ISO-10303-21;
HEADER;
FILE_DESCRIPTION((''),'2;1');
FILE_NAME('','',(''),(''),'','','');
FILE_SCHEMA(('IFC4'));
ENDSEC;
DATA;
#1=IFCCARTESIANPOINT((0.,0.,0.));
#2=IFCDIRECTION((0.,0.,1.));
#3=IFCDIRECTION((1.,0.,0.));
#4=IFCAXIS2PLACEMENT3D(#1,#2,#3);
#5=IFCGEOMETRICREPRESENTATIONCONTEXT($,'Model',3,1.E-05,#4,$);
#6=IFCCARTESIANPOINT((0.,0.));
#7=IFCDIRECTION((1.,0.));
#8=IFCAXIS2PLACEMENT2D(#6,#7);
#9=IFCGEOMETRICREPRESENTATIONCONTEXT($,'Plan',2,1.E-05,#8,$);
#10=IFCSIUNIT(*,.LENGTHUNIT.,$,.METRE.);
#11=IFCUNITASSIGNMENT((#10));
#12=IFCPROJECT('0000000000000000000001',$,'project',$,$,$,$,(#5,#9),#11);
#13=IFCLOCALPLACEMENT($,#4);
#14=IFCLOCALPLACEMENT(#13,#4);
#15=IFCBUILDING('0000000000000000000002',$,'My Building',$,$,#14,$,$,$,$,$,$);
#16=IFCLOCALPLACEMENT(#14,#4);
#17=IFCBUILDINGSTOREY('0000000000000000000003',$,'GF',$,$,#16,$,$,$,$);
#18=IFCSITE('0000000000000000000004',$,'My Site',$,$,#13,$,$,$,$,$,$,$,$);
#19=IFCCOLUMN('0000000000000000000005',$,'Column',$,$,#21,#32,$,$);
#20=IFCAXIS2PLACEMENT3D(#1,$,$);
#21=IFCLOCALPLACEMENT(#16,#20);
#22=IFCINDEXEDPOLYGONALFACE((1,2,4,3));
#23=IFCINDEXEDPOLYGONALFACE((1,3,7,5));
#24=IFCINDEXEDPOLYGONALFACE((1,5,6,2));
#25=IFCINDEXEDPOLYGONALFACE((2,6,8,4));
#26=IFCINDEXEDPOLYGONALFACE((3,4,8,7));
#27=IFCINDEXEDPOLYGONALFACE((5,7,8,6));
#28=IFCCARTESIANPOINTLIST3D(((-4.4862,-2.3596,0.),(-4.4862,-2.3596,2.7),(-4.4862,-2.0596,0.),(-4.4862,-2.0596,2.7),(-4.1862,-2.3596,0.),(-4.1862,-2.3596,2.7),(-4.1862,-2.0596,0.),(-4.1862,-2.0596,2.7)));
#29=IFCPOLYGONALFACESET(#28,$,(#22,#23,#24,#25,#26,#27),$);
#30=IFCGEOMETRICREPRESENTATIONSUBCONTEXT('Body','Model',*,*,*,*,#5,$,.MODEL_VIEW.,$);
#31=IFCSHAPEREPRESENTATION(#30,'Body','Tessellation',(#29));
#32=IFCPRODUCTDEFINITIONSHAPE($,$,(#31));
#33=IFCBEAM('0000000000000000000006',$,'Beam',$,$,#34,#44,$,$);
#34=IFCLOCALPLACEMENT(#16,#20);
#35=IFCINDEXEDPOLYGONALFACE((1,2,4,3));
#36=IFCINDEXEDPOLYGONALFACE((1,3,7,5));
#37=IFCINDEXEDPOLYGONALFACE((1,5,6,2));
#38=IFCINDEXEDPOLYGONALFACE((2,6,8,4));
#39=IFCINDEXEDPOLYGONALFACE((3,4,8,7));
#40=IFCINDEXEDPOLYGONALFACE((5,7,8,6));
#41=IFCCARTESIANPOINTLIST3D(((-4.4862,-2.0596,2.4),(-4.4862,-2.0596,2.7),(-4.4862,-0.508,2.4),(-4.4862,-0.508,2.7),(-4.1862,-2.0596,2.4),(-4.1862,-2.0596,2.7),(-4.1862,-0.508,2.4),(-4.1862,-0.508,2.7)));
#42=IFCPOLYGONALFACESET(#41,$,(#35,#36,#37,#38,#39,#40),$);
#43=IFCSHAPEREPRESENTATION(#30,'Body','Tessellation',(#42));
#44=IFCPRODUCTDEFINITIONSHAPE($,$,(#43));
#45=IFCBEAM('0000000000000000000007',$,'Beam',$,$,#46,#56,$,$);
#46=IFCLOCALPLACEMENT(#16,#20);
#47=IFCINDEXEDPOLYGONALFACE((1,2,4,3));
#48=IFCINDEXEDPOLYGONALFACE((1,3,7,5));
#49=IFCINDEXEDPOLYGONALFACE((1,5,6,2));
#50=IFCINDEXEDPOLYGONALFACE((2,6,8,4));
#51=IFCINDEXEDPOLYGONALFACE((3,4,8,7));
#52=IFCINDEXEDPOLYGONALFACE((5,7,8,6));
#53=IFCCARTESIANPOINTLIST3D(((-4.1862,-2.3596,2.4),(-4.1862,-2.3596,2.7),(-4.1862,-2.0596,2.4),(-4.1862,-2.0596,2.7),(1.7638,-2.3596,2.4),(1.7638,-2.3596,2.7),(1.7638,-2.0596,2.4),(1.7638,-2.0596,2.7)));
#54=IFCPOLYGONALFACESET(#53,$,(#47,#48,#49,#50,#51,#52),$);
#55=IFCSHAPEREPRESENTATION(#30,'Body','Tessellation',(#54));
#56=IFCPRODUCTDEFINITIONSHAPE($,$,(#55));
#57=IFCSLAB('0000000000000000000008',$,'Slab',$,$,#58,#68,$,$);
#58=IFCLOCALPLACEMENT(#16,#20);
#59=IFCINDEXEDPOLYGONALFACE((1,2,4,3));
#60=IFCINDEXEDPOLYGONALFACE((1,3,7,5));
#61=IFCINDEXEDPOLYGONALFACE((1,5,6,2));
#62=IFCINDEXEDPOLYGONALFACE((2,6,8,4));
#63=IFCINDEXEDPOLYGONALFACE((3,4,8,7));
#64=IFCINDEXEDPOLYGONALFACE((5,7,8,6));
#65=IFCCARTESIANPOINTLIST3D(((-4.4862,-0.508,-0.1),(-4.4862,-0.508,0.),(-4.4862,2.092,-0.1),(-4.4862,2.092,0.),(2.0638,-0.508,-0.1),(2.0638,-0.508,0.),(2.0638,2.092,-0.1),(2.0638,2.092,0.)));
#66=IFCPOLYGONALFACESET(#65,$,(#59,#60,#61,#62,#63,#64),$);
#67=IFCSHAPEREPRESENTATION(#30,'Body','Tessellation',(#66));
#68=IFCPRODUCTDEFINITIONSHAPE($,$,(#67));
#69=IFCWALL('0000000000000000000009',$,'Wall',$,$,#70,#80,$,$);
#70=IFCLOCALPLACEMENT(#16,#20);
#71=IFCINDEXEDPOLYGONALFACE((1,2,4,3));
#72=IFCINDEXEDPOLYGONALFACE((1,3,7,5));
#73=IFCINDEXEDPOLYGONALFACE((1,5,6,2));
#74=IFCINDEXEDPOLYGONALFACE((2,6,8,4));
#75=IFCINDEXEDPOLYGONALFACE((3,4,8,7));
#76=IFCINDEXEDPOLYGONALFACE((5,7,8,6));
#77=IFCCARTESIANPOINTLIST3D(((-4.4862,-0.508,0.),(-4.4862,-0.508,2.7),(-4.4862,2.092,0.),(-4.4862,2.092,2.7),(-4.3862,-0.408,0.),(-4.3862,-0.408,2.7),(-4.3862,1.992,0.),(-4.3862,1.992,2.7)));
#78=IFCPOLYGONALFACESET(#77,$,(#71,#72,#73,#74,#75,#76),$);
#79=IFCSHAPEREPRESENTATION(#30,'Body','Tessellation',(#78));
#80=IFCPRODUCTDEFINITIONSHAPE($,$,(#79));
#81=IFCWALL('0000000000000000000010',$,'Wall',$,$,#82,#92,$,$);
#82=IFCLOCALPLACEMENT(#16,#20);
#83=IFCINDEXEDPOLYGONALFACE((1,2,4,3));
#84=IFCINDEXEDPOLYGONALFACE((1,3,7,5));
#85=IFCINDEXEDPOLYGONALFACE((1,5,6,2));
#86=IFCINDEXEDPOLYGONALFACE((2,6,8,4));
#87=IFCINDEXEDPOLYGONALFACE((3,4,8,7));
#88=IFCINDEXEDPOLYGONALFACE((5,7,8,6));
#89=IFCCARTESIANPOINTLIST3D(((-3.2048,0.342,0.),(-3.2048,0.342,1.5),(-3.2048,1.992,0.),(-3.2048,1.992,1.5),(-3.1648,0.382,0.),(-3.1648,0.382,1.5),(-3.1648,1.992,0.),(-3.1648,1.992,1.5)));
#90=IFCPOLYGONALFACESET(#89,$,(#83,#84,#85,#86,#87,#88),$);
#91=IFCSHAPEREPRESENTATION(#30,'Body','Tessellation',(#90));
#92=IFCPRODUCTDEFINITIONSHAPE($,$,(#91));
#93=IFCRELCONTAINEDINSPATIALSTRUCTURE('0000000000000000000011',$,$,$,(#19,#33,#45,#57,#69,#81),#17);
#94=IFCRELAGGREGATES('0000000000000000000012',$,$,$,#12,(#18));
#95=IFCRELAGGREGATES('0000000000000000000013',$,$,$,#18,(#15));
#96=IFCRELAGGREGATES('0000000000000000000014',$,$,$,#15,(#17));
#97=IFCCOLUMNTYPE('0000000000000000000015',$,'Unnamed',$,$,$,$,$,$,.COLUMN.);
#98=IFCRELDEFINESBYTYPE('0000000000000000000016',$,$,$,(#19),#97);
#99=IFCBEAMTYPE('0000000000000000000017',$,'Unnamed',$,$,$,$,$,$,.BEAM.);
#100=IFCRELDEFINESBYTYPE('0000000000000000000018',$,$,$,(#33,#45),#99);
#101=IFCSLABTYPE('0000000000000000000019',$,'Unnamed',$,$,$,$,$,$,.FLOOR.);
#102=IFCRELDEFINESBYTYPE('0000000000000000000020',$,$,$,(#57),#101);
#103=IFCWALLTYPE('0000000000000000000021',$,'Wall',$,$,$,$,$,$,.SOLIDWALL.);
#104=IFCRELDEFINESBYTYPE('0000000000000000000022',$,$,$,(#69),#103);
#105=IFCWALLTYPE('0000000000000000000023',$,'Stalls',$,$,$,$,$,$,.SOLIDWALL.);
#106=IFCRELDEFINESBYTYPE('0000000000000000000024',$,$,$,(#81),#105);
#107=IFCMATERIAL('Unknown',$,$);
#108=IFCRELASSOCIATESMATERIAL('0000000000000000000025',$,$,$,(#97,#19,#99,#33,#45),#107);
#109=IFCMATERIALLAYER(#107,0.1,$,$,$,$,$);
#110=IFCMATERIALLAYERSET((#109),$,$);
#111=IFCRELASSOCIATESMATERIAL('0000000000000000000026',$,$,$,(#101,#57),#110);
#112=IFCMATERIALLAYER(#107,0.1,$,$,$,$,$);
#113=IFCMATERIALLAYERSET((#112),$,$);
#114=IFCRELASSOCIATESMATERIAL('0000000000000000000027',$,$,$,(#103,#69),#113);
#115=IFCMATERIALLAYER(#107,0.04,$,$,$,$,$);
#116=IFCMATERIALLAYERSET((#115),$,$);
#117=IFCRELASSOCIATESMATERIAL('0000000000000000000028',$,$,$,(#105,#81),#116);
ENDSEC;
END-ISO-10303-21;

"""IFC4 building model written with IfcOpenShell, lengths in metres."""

from ifc_helpers import new_model, si_unit, frame, origin_with_axes, origin_2d_with_axis, place, context, subcontext, project, spatial, line, indexed_curve, rectangle, outline, extrude, material, layer, layer_set, layer_usage, material_profile, profile_set, profile_usage, type_object, element, save


model = new_model("IFC4")

# Units and contexts
model_context = context("Model", 3, precision=1e-05, world=origin_with_axes())
plan_context = context("Plan", 2, precision=1e-05, world=origin_2d_with_axis())
body_context_1 = subcontext(model_context, "Body", "Model", "MODEL_VIEW")
ifc_project = project(units=[si_unit("LENGTHUNIT", "METRE")], contexts=[model_context, plan_context])

# Site, building, storey
site_placement = place(None, origin_with_axes())
site = spatial("IfcSite", under=ifc_project, at=site_placement, Name="My Site")
building_placement = place(site_placement, origin_with_axes())
building = spatial("IfcBuilding", under=site, at=building_placement, Name="My Building")
storey_placement = place(building_placement, origin_with_axes())
storey = spatial("IfcBuildingStorey", under=building, at=storey_placement, Name="GF")

# Column
ifc_material = material(Name="Unknown")
ifc_material_profile_1 = material_profile(ifc_material, rectangle(XDim=0.3, YDim=0.3))
ifc_profile_set_1 = profile_set([ifc_material_profile_1])
ifc_profile_usage_1 = profile_usage(ifc_profile_set_1, cardinal=6)
column_type = type_object("IfcColumnType", Name="Unnamed", PredefinedType="COLUMN", material=ifc_profile_set_1)
column_placement = place(storey_placement, frame((-4.4862, -2.2096, 0.0), z_axis=(0.0, 0.0, 1.0), x_axis=(1.0, 0.0, 0.0)))
element("IfcColumn", 1, at=column_placement, inside=storey, type_object=column_type, material=ifc_profile_usage_1, Name="Column", context=body_context_1, shape_type="SweptSolid", body=[
    extrude(rectangle(XDim=0.3, YDim=0.3), frame((0.15, 0.0, 0.0), z_axis=(0.0, 0.0, 1.0), x_axis=(1.0, 0.0, 0.0)), (0.0, 0.0, 1.0), 2.7),
])

# Beams
ifc_material_profile_2 = material_profile(ifc_material, rectangle(XDim=0.3, YDim=0.3))
ifc_profile_set_2 = profile_set([ifc_material_profile_2])
ifc_profile_usage_2 = profile_usage(ifc_profile_set_2, cardinal=9)
beam_type = type_object("IfcBeamType", Name="Unnamed", PredefinedType="BEAM", material=ifc_profile_set_2)
beam_1_placement = place(storey_placement, frame((-4.4862, -0.508, 2.7), z_axis=(0.0, -1.0, 0.0), x_axis=(1.0, 0.0, 0.0)))
element("IfcBeam", 2, at=beam_1_placement, inside=storey, type_object=beam_type, material=ifc_profile_usage_2, Name="Beam", context=body_context_1, shape_type="SweptSolid", body=[
    extrude(rectangle(XDim=0.3, YDim=0.3), frame((0.15, -0.15, 0.0), z_axis=(0.0, 0.0, 1.0), x_axis=(1.0, 0.0, 0.0)), (0.0, 0.0, 1.0), 1.5515),
])
ifc_profile_usage_3 = profile_usage(ifc_profile_set_2, cardinal=7)
beam_2_placement = place(storey_placement, frame((-4.1862, -2.0596, 2.7), z_axis=(1.0, 0.0, 0.0), x_axis=(0.0, 1.0, 0.0)))
element("IfcBeam", 3, at=beam_2_placement, inside=storey, type_object=beam_type, material=ifc_profile_usage_3, Name="Beam", context=body_context_1, shape_type="SweptSolid", body=[
    extrude(rectangle(XDim=0.3, YDim=0.3), frame((-0.15, -0.15, 0.0), z_axis=(0.0, 0.0, 1.0), x_axis=(1.0, 0.0, 0.0)), (0.0, 0.0, 1.0), 5.95),
])

# Slab
ifc_layer_1 = layer(ifc_material, 0.1)
ifc_layer_set_1 = layer_set([ifc_layer_1])
ifc_layer_usage_1 = layer_usage(ifc_layer_set_1, "AXIS3", "POSITIVE", -0.1)
slab_type = type_object("IfcSlabType", Name="Unnamed", PredefinedType="FLOOR", material=ifc_layer_set_1)
slab_placement = place(storey_placement, frame((-4.4862, 2.092, 0.0), z_axis=(0.0, 0.0, 1.0), x_axis=(1.0, 0.0, 0.0)))
element("IfcSlab", 4, at=slab_placement, inside=storey, type_object=slab_type, material=ifc_layer_usage_1, Name="Slab", context=body_context_1, shape_type="SweptSolid", body=[
    extrude(outline(indexed_curve([(0.0, 0.0), (0.0, -2.6), (6.55, -2.6), (6.55, 0.0), (0.0, 0.0)])), frame((0.0, 0.0, -0.1), z_axis=(0.0, 0.0, 1.0), x_axis=(1.0, 0.0, 0.0)), (0.0, 0.0, 1.0), 0.1),
])

# Wall
ifc_layer_2 = layer(ifc_material, 0.1)
ifc_layer_set_2 = layer_set([ifc_layer_2])
ifc_layer_usage_2 = layer_usage(ifc_layer_set_2, "AXIS2", "POSITIVE", 0.0)
wall_type_1 = type_object("IfcWallType", Name="Wall", PredefinedType="SOLIDWALL", material=ifc_layer_set_2)
wall_1_placement = place(storey_placement, frame((-4.4862, 2.092, 0.0), z_axis=(0.0, 0.0, 1.0), x_axis=(0.0, -1.0, 0.0)))
element("IfcWall", 5, at=wall_1_placement, inside=storey, type_object=wall_type_1, material=ifc_layer_usage_2, Name="Wall", context=body_context_1, shape_type="SweptSolid", body=[
    extrude(outline(indexed_curve([(0.0, 0.0), (0.1, 0.1), (2.5, 0.1), (2.6, 0.0)], segments=[line(1, 2, 3, 4, 1)])), origin_with_axes(), (0.0, 0.0, 1.0), 2.7),
])

# Wall
ifc_layer_3 = layer(ifc_material, 0.04)
ifc_layer_set_3 = layer_set([ifc_layer_3])
ifc_layer_usage_3 = layer_usage(ifc_layer_set_3, "AXIS2", "POSITIVE", 0.0)
wall_type_2 = type_object("IfcWallType", Name="Stalls", PredefinedType="SOLIDWALL", material=ifc_layer_set_3)
wall_2_placement = place(storey_placement, frame((-3.2048, 1.992, 0.0), z_axis=(0.0, 0.0, 1.0), x_axis=(0.0, -1.0, 0.0)))
element("IfcWall", 6, at=wall_2_placement, inside=storey, type_object=wall_type_2, material=ifc_layer_usage_3, Name="Wall", context=body_context_1, shape_type="SweptSolid", body=[
    extrude(outline(indexed_curve([(0.0, 0.0), (0.0, 0.04), (1.61, 0.04), (1.65, 0.0)], segments=[line(1, 2, 3, 4, 1)])), origin_with_axes(), (0.0, 0.0, 1.0), 1.5),
])

save(model, "model.ifc")
